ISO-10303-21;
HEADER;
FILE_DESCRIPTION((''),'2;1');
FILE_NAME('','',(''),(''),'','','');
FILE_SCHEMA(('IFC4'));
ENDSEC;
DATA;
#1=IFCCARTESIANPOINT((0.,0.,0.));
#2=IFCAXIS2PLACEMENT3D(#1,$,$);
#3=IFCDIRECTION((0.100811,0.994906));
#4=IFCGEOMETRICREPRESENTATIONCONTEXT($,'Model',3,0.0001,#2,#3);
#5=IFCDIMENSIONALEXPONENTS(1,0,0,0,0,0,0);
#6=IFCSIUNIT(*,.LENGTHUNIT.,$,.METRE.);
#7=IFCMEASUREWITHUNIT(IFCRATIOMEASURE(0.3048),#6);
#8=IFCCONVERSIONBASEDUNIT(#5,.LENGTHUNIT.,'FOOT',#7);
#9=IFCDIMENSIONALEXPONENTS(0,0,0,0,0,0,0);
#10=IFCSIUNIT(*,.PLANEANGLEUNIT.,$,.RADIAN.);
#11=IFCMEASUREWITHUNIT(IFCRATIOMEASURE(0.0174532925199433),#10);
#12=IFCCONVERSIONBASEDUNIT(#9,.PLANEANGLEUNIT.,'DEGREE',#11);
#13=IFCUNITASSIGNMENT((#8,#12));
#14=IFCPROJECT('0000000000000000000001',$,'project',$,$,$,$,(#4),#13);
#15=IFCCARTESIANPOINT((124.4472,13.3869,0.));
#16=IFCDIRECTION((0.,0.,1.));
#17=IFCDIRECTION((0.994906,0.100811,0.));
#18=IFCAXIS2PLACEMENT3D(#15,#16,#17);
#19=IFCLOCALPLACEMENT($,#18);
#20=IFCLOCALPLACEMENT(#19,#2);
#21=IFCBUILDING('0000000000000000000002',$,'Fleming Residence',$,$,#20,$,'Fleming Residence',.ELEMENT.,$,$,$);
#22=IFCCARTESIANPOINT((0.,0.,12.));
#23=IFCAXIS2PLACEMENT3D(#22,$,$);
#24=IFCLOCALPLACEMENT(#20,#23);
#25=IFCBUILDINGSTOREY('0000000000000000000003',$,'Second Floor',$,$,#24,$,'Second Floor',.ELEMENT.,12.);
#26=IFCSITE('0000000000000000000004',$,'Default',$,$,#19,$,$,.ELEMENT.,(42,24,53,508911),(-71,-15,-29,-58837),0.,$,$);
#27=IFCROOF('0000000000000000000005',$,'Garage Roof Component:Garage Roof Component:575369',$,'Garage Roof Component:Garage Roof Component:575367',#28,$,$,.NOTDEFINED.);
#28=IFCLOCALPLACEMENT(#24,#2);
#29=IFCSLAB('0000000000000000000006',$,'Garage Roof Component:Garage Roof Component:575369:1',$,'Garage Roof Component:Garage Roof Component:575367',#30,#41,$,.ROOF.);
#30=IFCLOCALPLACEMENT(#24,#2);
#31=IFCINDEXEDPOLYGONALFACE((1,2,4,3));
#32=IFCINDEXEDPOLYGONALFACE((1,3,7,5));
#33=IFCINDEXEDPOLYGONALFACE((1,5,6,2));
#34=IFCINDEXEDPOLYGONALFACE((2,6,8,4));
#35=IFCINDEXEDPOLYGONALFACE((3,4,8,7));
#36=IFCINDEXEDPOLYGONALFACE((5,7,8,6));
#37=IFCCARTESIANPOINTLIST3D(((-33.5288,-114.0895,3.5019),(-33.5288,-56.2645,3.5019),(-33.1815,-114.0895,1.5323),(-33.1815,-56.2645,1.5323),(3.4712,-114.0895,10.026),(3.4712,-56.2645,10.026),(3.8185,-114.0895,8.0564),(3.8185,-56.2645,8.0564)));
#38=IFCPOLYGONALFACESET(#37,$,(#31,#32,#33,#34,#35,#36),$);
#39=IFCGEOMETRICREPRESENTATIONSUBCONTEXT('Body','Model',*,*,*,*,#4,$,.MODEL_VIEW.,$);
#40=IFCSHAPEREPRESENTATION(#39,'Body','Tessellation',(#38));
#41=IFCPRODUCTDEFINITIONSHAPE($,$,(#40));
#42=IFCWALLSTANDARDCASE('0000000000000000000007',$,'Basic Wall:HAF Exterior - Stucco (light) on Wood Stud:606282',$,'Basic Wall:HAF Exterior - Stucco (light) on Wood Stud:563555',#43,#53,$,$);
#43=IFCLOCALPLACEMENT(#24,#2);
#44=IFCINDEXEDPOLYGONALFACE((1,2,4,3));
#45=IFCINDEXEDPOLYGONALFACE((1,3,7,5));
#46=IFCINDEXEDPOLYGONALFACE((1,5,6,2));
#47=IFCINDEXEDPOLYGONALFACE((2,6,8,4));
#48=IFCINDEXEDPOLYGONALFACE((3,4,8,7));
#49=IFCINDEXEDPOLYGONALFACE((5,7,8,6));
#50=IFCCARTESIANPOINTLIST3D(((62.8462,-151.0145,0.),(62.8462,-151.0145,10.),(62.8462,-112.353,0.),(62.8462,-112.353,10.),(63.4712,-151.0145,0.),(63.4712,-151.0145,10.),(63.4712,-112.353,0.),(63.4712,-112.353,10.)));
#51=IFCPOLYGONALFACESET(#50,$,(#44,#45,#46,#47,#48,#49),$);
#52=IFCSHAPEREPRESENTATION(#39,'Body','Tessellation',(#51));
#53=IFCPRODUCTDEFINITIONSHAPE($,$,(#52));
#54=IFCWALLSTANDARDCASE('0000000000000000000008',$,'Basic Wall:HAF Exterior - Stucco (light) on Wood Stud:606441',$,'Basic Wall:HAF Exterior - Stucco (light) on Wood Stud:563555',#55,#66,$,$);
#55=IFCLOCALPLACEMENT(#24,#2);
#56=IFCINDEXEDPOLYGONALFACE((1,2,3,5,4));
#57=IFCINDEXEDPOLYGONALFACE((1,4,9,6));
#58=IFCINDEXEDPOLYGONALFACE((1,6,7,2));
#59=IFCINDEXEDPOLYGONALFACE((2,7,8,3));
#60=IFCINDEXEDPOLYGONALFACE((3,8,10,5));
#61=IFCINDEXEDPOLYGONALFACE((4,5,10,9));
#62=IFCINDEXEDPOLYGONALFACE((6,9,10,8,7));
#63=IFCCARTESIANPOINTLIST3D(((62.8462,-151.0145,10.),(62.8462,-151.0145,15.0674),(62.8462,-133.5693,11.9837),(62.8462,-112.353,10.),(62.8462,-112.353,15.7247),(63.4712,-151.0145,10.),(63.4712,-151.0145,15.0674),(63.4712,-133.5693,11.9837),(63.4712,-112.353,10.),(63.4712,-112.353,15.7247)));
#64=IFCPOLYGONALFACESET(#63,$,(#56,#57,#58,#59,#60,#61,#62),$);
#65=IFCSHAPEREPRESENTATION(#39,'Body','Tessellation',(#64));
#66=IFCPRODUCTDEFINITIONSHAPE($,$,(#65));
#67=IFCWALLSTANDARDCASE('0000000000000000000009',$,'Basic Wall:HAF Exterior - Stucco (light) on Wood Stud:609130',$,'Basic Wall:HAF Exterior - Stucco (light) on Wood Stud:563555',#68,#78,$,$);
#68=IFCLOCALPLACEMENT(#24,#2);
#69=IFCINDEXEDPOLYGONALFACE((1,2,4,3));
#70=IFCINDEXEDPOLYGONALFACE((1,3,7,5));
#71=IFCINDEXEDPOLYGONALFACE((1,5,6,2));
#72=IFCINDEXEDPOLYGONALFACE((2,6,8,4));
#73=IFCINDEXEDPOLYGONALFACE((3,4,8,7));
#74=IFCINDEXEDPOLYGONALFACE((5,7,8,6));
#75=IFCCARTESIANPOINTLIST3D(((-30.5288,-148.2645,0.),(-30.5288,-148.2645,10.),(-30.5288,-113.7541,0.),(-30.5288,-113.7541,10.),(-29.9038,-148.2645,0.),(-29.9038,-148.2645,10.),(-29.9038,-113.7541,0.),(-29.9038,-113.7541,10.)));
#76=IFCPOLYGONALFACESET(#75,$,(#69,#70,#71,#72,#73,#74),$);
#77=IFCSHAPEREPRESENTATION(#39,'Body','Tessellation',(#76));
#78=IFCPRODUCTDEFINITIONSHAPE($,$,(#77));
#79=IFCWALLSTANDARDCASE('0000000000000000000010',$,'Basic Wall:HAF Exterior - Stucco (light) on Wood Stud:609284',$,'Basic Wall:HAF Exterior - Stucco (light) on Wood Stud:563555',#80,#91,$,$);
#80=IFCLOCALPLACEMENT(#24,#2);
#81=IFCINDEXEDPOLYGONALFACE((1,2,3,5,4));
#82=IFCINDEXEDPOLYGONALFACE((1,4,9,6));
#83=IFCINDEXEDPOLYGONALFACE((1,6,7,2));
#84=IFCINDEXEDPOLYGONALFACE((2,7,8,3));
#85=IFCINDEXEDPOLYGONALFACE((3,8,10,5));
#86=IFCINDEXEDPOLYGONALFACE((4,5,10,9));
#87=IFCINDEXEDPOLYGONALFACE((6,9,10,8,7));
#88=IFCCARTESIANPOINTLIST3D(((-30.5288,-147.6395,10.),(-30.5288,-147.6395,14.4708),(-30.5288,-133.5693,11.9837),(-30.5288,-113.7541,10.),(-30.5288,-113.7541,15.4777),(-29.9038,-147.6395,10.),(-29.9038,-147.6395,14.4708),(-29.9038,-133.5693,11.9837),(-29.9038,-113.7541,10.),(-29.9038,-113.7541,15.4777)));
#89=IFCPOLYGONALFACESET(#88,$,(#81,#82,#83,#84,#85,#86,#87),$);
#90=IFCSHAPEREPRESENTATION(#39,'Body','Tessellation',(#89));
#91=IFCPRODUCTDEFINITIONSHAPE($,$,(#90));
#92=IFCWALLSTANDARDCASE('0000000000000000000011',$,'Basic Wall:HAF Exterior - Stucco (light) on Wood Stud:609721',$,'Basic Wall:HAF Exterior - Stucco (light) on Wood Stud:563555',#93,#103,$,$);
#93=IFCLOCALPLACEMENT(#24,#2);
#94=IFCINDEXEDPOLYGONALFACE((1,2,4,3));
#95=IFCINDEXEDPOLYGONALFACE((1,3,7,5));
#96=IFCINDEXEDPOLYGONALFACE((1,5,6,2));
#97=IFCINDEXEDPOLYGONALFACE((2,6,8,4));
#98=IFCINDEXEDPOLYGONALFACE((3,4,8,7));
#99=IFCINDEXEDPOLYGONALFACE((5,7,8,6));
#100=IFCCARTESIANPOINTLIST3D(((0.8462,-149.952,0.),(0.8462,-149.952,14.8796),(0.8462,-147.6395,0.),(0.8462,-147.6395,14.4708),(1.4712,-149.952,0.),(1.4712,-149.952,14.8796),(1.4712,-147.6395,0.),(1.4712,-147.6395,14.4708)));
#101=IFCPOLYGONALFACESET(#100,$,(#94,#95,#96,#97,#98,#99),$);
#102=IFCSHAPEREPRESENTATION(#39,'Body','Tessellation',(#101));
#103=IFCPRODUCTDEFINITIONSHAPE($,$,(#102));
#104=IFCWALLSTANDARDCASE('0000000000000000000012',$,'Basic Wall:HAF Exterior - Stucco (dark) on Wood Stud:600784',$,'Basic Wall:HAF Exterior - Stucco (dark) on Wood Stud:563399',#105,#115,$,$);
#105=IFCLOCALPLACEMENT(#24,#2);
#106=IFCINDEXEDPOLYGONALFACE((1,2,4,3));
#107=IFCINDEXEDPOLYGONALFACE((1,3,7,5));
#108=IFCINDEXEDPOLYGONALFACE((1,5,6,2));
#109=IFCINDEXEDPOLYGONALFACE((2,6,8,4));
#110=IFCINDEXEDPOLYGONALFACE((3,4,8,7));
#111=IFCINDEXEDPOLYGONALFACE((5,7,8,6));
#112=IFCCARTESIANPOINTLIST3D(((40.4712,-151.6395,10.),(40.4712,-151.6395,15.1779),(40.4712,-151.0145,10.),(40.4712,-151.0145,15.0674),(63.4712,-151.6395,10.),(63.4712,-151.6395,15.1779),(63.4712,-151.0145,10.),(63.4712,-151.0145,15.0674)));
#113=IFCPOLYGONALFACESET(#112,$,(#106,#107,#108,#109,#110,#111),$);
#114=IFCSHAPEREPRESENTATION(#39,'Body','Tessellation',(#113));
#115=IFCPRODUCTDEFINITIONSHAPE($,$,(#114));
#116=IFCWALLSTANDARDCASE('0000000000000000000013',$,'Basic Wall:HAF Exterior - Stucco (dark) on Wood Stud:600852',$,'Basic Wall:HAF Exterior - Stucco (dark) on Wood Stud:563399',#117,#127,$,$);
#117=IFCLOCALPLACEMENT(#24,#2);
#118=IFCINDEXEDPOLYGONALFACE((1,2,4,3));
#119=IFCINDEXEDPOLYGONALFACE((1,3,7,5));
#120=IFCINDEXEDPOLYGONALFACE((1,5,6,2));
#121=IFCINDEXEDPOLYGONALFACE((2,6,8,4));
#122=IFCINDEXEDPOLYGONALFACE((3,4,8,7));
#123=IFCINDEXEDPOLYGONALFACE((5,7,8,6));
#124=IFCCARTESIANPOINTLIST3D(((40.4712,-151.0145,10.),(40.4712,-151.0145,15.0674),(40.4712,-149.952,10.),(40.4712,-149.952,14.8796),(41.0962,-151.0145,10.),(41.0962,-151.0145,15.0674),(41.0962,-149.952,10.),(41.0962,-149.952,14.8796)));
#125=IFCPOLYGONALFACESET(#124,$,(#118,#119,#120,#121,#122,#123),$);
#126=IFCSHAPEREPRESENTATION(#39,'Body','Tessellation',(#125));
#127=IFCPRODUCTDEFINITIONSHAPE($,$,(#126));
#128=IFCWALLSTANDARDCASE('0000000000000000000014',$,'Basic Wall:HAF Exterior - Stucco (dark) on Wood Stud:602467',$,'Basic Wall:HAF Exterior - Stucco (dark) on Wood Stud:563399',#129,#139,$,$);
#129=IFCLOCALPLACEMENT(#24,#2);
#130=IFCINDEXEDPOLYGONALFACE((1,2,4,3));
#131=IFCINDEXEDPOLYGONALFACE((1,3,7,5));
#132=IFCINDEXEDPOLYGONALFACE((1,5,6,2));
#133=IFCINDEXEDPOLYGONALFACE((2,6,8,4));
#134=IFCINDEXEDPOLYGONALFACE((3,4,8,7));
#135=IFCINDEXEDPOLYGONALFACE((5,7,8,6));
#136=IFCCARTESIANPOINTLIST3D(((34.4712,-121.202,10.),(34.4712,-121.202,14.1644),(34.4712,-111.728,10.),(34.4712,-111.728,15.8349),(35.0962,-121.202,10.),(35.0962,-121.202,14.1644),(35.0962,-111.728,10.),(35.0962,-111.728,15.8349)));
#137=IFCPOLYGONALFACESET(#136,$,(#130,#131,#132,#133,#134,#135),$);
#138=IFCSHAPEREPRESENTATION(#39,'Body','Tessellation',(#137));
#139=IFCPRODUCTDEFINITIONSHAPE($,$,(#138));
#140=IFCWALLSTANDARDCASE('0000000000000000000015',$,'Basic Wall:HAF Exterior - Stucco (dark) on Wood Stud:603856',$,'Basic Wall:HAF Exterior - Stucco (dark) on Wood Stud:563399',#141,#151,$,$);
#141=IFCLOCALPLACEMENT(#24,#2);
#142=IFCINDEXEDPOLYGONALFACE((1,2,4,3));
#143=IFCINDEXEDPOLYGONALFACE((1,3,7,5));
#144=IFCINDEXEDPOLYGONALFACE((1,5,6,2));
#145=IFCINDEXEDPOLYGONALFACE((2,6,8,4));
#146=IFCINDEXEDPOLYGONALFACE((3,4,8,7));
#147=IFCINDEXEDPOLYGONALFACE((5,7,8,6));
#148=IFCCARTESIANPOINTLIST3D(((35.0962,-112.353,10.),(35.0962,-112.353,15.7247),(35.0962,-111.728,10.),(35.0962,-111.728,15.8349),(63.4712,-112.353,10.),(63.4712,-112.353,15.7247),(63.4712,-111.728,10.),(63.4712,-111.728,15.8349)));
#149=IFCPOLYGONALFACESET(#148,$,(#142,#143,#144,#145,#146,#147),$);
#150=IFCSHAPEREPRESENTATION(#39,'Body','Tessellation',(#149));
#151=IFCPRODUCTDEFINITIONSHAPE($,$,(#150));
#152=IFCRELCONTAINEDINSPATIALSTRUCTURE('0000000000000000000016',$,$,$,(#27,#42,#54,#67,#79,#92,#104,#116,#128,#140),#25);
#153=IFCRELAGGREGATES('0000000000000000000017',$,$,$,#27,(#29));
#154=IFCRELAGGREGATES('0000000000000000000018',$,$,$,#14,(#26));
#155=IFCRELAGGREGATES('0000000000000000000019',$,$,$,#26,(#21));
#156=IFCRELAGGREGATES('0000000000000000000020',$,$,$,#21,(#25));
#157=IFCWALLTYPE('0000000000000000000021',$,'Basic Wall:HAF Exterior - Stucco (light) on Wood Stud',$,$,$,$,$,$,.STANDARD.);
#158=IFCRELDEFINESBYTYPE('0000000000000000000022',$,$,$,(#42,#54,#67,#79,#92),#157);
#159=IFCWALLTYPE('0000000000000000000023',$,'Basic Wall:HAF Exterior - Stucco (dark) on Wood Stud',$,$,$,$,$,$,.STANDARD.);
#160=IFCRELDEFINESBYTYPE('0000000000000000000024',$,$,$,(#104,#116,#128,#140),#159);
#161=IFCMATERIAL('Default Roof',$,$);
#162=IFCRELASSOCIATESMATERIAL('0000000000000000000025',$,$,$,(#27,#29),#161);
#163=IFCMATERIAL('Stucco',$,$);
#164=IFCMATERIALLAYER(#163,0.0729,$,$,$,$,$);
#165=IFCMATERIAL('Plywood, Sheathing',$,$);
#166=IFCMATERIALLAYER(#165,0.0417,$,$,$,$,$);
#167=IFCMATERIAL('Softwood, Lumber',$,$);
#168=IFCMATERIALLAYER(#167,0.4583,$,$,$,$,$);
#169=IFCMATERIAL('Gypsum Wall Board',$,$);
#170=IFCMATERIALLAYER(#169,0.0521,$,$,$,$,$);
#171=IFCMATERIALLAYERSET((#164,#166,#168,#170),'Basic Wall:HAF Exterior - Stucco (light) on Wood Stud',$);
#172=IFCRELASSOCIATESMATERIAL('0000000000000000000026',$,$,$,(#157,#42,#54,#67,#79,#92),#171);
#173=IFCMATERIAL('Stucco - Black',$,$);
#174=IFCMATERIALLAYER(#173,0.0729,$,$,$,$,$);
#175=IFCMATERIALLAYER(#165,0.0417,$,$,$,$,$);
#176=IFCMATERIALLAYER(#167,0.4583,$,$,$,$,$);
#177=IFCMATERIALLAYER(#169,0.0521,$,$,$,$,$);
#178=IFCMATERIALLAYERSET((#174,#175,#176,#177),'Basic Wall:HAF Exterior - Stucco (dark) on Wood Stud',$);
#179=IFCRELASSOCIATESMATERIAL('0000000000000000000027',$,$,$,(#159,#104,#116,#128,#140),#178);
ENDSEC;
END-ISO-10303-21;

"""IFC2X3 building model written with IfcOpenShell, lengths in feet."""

from ifc_helpers import new_model, entity, si_unit, converted_unit, direction, frame, frame_2d, origin, place, context, subcontext, project, spatial, polyline, rectangle, extrude, clip, bounded_halfspace, material, layer, layer_set, layer_usage, type_object, element, aggregate, save


model = new_model("IFC2X3")

# Units and contexts
model_context = context("Model", 3, precision=0.0001, world=origin(), true_north=direction((0.100811, 0.994906)))
body_context = subcontext(model_context, "Body", "Model", "MODEL_VIEW")
ifc_project = project(units=[converted_unit("LENGTHUNIT", "FOOT", entity("IfcRatioMeasure", 0.3048), si_unit("LENGTHUNIT", "METRE"), dimensions=[1, 0, 0, 0, 0, 0, 0]), converted_unit("PLANEANGLEUNIT", "DEGREE", entity("IfcRatioMeasure", 0.0174532925199433), si_unit("PLANEANGLEUNIT", "RADIAN"), dimensions=[0, 0, 0, 0, 0, 0, 0])], contexts=[model_context])

# Site, building, storey
site_placement = place(None, frame((124.4472, 13.3869, 0.0), z_axis=(0.0, 0.0, 1.0), x_axis=(0.994906, 0.100811, 0.0)))
site = spatial("IfcSite", under=ifc_project, at=site_placement, Name="Default", CompositionType="ELEMENT", RefLatitude=(42, 24, 53, 508911), RefLongitude=(-71, -15, -29, -58837), RefElevation=0.0)
building_placement = place(site_placement, origin())
building = spatial("IfcBuilding", under=site, at=building_placement, Name="Fleming Residence", LongName="Fleming Residence", CompositionType="ELEMENT")
storey_placement = place(building_placement, frame((0.0, 0.0, 12.0)))
storey = spatial("IfcBuildingStorey", under=building, at=storey_placement, Name="Second Floor", LongName="Second Floor", CompositionType="ELEMENT", Elevation=12.0)

# Roof, slab
ifc_material_1 = material(Name="Default Roof")
roof_placement = place(storey_placement, origin())
roof = element("IfcRoof", 1, at=roof_placement, inside=storey, material=ifc_material_1, Name="Garage Roof Component:Garage Roof Component:575369", ObjectType="Garage Roof Component:Garage Roof Component:575367", ShapeType="NOTDEFINED")
slab_placement = place(storey_placement, origin())
slab = element("IfcSlab", 2, at=slab_placement, material=ifc_material_1, Name="Garage Roof Component:Garage Roof Component:575369:1", ObjectType="Garage Roof Component:Garage Roof Component:575367", PredefinedType="ROOF", context=body_context, shape_type="SweptSolid", body=[
    extrude(rectangle(XDim=2.0, YDim=37.5708, at=frame_2d((0.0, 0.0), x_axis=(0.0, 1.0))), frame((-14.8551, -114.0895, 5.7792), z_axis=(0.0, 1.0, 0.0), x_axis=(0.984808, 0.0, 0.173648)), (0.0, 0.0, 1.0), 57.825),
])
aggregate(roof, [slab])

# Walls
ifc_material_2 = material(Name="Stucco")
ifc_layer_1 = layer(ifc_material_2, 0.0729)
ifc_material_3 = material(Name="Plywood, Sheathing")
ifc_layer_2 = layer(ifc_material_3, 0.0417)
ifc_material_4 = material(Name="Softwood, Lumber")
ifc_layer_3 = layer(ifc_material_4, 0.4583)
ifc_material_5 = material(Name="Gypsum Wall Board")
ifc_layer_4 = layer(ifc_material_5, 0.0521)
ifc_layer_set_1 = layer_set([ifc_layer_1, ifc_layer_2, ifc_layer_3, ifc_layer_4], Name="Basic Wall:HAF Exterior - Stucco (light) on Wood Stud")
ifc_layer_usage_1 = layer_usage(ifc_layer_set_1, "AXIS2", "NEGATIVE", 0.3125)
wall_type_1 = type_object("IfcWallType", Name="Basic Wall:HAF Exterior - Stucco (light) on Wood Stud", PredefinedType="STANDARD", material=ifc_layer_set_1)
wall_1_placement = place(storey_placement, frame((63.1587, -112.353, 0.0), z_axis=(0.0, 0.0, 1.0), x_axis=(0.0, -1.0, 0.0)))
element("IfcWallStandardCase", 3, at=wall_1_placement, inside=storey, type_object=wall_type_1, material=ifc_layer_usage_1, Name="Basic Wall:HAF Exterior - Stucco (light) on Wood Stud:606282", ObjectType="Basic Wall:HAF Exterior - Stucco (light) on Wood Stud:563555", context=body_context, shape_type="SweptSolid", body=[
    extrude(rectangle(XDim=38.6615, YDim=0.625, at=frame_2d((19.3307, 0.0), x_axis=(-1.0, 0.0))), origin(), (0.0, 0.0, 1.0), 10.0),
])
ifc_layer_usage_2 = layer_usage(ifc_layer_set_1, "AXIS2", "NEGATIVE", 0.3125)
wall_2_placement = place(storey_placement, frame((63.1587, -112.353, 10.0), z_axis=(0.0, 0.0, 1.0), x_axis=(0.0, -1.0, 0.0)))
element("IfcWallStandardCase", 4, at=wall_2_placement, inside=storey, type_object=wall_type_1, material=ifc_layer_usage_2, Name="Basic Wall:HAF Exterior - Stucco (light) on Wood Stud:606441", ObjectType="Basic Wall:HAF Exterior - Stucco (light) on Wood Stud:563555", context=body_context, shape_type="Clipping", body=[
    clip(clip(extrude(rectangle(XDim=38.6615, YDim=0.625, at=frame_2d((19.3307, 0.0), x_axis=(-1.0, 0.0))), origin(), (0.0, 0.0, 1.0), 5.7247), bounded_halfspace(frame((21.2163, -0.3125, 1.9837), z_axis=(0.174064, 0.0, -0.984734), x_axis=(0.0, -1.0, 0.0)), True, frame((21.2163, -0.3125, 1.9837)), polyline([(0.0, 0.0), (17.4451, 0.0), (17.4451, 0.625), (0.0, 0.625), (0.0, 0.0)]))), bounded_halfspace(frame((0.0, -0.3125, 5.7247), z_axis=(-0.173648, 0.0, -0.984808), x_axis=(0.0, -1.0, 0.0)), True, frame((0.0, -0.3125, 5.7247)), polyline([(0.0, 0.0), (21.2163, 0.0), (21.2163, 0.625), (0.0, 0.625), (0.0, 0.0)]))),
])
ifc_layer_usage_3 = layer_usage(ifc_layer_set_1, "AXIS2", "NEGATIVE", 0.3125)
wall_3_placement = place(storey_placement, frame((-30.2163, -148.2645, 0.0), z_axis=(0.0, 0.0, 1.0), x_axis=(0.0, 1.0, 0.0)))
element("IfcWallStandardCase", 5, at=wall_3_placement, inside=storey, type_object=wall_type_1, material=ifc_layer_usage_3, Name="Basic Wall:HAF Exterior - Stucco (light) on Wood Stud:609130", ObjectType="Basic Wall:HAF Exterior - Stucco (light) on Wood Stud:563555", context=body_context, shape_type="SweptSolid", body=[
    extrude(rectangle(XDim=34.5104, YDim=0.625, at=frame_2d((17.2552, 0.0), x_axis=(-1.0, 0.0))), origin(), (0.0, 0.0, 1.0), 10.0),
])
ifc_layer_usage_4 = layer_usage(ifc_layer_set_1, "AXIS2", "NEGATIVE", 0.3125)
wall_4_placement = place(storey_placement, frame((-30.2163, -147.6395, 10.0), z_axis=(0.0, 0.0, 1.0), x_axis=(0.0, 1.0, 0.0)))
element("IfcWallStandardCase", 6, at=wall_4_placement, inside=storey, type_object=wall_type_1, material=ifc_layer_usage_4, Name="Basic Wall:HAF Exterior - Stucco (light) on Wood Stud:609284", ObjectType="Basic Wall:HAF Exterior - Stucco (light) on Wood Stud:563555", context=body_context, shape_type="Clipping", body=[
    clip(clip(extrude(rectangle(XDim=33.8854, YDim=0.625, at=frame_2d((16.9427, 0.0), x_axis=(-1.0, 0.0))), origin(), (0.0, 0.0, 1.0), 5.4777), bounded_halfspace(frame((0.0, -0.3125, 4.4708), z_axis=(-0.174064, 0.0, -0.984734), x_axis=(0.0, 1.0, 0.0)), True, frame((0.0, -0.3125, 4.4708)), polyline([(0.0, 0.0), (14.0701, 0.0), (14.0701, 0.625), (0.0, 0.625), (0.0, 0.0)]))), bounded_halfspace(frame((14.0701, -0.3125, 1.9837), z_axis=(0.173648, 0.0, -0.984808), x_axis=(0.0, 1.0, 0.0)), True, frame((14.0701, -0.3125, 1.9837)), polyline([(0.0, 0.0), (19.4194, 0.0), (19.8153, 0.0), (19.8153, 0.625), (0.0, 0.625), (0.0, 0.0)]))),
])
ifc_layer_usage_5 = layer_usage(ifc_layer_set_1, "AXIS2", "NEGATIVE", 0.3125)
wall_5_placement = place(storey_placement, frame((1.1587, -149.952, 0.0), z_axis=(0.0, 0.0, 1.0), x_axis=(0.0, 1.0, 0.0)))
element("IfcWallStandardCase", 7, at=wall_5_placement, inside=storey, type_object=wall_type_1, material=ifc_layer_usage_5, Name="Basic Wall:HAF Exterior - Stucco (light) on Wood Stud:609721", ObjectType="Basic Wall:HAF Exterior - Stucco (light) on Wood Stud:563555", context=body_context, shape_type="Clipping", body=[
    clip(extrude(rectangle(XDim=2.3125, YDim=0.625, at=frame_2d((1.1562, 0.0), x_axis=(-1.0, 0.0))), origin(), (0.0, 0.0, 1.0), 14.8796), bounded_halfspace(frame((0.0, -0.3125, 14.8796), z_axis=(-0.174064, 0.0, -0.984734), x_axis=(0.0, 1.0, 0.0)), True, frame((0.0, -0.3125, 14.8796)), polyline([(0.0, 0.0), (2.3125, 0.0), (2.3125, 0.625), (1.6875, 0.625), (0.0, 0.625), (0.0, 0.0)]))),
])
ifc_material_6 = material(Name="Stucco - Black")
ifc_layer_5 = layer(ifc_material_6, 0.0729)
ifc_layer_6 = layer(ifc_material_3, 0.0417)
ifc_layer_7 = layer(ifc_material_4, 0.4583)
ifc_layer_8 = layer(ifc_material_5, 0.0521)
ifc_layer_set_2 = layer_set([ifc_layer_5, ifc_layer_6, ifc_layer_7, ifc_layer_8], Name="Basic Wall:HAF Exterior - Stucco (dark) on Wood Stud")
ifc_layer_usage_6 = layer_usage(ifc_layer_set_2, "AXIS2", "POSITIVE", -0.3125)
wall_type_2 = type_object("IfcWallType", Name="Basic Wall:HAF Exterior - Stucco (dark) on Wood Stud", PredefinedType="STANDARD", material=ifc_layer_set_2)
wall_6_placement = place(storey_placement, frame((40.4712, -151.327, 10.0)))
element("IfcWallStandardCase", 8, at=wall_6_placement, inside=storey, type_object=wall_type_2, material=ifc_layer_usage_6, Name="Basic Wall:HAF Exterior - Stucco (dark) on Wood Stud:600784", ObjectType="Basic Wall:HAF Exterior - Stucco (dark) on Wood Stud:563399", context=body_context, shape_type="Clipping", body=[
    clip(extrude(rectangle(XDim=23.0, YDim=0.625, at=frame_2d((11.5, 0.0), x_axis=(-1.0, 0.0))), origin(), (0.0, 0.0, 1.0), 5.1779), bounded_halfspace(frame((0.0, -0.3125, 5.1779), z_axis=(0.0, -0.174064, -0.984734), x_axis=(-1.0, 0.0, 0.0)), True, frame((0.0, -0.3125, 5.1779)), polyline([(0.0, 0.0), (23.0, 0.0), (23.0, 0.625), (22.375, 0.625), (0.625, 0.625), (0.0, 0.625), (0.0, 0.0)]))),
])
ifc_layer_usage_7 = layer_usage(ifc_layer_set_2, "AXIS2", "NEGATIVE", 0.3125)
wall_7_placement = place(storey_placement, frame((40.7837, -151.0145, 10.0), z_axis=(0.0, 0.0, 1.0), x_axis=(0.0, 1.0, 0.0)))
element("IfcWallStandardCase", 9, at=wall_7_placement, inside=storey, type_object=wall_type_2, material=ifc_layer_usage_7, Name="Basic Wall:HAF Exterior - Stucco (dark) on Wood Stud:600852", ObjectType="Basic Wall:HAF Exterior - Stucco (dark) on Wood Stud:563399", context=body_context, shape_type="Clipping", body=[
    clip(extrude(rectangle(XDim=1.0625, YDim=0.625, at=frame_2d((0.5313, 0.0), x_axis=(-1.0, 0.0))), origin(), (0.0, 0.0, 1.0), 5.0674), bounded_halfspace(frame((0.0, -0.3125, 5.0674), z_axis=(-0.174064, 0.0, -0.984734), x_axis=(0.0, 1.0, 0.0)), True, frame((0.0, -0.3125, 5.0674)), polyline([(0.0, 0.0), (1.0625, 0.0), (1.0625, 0.625), (0.0, 0.625), (0.0, 0.0)]))),
])
ifc_layer_usage_8 = layer_usage(ifc_layer_set_2, "AXIS2", "NEGATIVE", 0.3125)
wall_8_placement = place(storey_placement, frame((34.7837, -121.202, 10.0), z_axis=(0.0, 0.0, 1.0), x_axis=(0.0, 1.0, 0.0)))
element("IfcWallStandardCase", 10, at=wall_8_placement, inside=storey, type_object=wall_type_2, material=ifc_layer_usage_8, Name="Basic Wall:HAF Exterior - Stucco (dark) on Wood Stud:602467", ObjectType="Basic Wall:HAF Exterior - Stucco (dark) on Wood Stud:563399", context=body_context, shape_type="Clipping", body=[
    clip(extrude(rectangle(XDim=9.474, YDim=0.625, at=frame_2d((4.737, 0.0), x_axis=(-1.0, 0.0))), origin(), (0.0, 0.0, 1.0), 5.8349), bounded_halfspace(frame((0.0, -0.3125, 4.1644), z_axis=(0.173648, 0.0, -0.984808), x_axis=(0.0, 1.0, 0.0)), True, frame((0.0, -0.3125, 4.1644)), polyline([(0.0, 0.0), (8.849, 0.0), (9.474, 0.0), (9.474, 0.625), (0.0, 0.625), (0.0, 0.0)]))),
])
ifc_layer_usage_9 = layer_usage(ifc_layer_set_2, "AXIS2", "NEGATIVE", 0.3125)
wall_9_placement = place(storey_placement, frame((35.0962, -112.0405, 10.0)))
element("IfcWallStandardCase", 11, at=wall_9_placement, inside=storey, type_object=wall_type_2, material=ifc_layer_usage_9, Name="Basic Wall:HAF Exterior - Stucco (dark) on Wood Stud:603856", ObjectType="Basic Wall:HAF Exterior - Stucco (dark) on Wood Stud:563399", context=body_context, shape_type="Clipping", body=[
    clip(extrude(rectangle(XDim=28.375, YDim=0.625, at=frame_2d((14.1875, 0.0), x_axis=(-1.0, 0.0))), origin(), (0.0, 0.0, 1.0), 5.8349), bounded_halfspace(frame((0.0, -0.3125, 5.7247), z_axis=(0.0, 0.173648, -0.984808), x_axis=(-1.0, 0.0, 0.0)), True, frame((0.0, -0.3125, 5.7247)), polyline([(0.0, 0.0), (27.75, 0.0), (28.375, 0.0), (28.375, 0.625), (0.0, 0.625), (0.0, 0.0)]))),
])

save(model, "model.ifc")
